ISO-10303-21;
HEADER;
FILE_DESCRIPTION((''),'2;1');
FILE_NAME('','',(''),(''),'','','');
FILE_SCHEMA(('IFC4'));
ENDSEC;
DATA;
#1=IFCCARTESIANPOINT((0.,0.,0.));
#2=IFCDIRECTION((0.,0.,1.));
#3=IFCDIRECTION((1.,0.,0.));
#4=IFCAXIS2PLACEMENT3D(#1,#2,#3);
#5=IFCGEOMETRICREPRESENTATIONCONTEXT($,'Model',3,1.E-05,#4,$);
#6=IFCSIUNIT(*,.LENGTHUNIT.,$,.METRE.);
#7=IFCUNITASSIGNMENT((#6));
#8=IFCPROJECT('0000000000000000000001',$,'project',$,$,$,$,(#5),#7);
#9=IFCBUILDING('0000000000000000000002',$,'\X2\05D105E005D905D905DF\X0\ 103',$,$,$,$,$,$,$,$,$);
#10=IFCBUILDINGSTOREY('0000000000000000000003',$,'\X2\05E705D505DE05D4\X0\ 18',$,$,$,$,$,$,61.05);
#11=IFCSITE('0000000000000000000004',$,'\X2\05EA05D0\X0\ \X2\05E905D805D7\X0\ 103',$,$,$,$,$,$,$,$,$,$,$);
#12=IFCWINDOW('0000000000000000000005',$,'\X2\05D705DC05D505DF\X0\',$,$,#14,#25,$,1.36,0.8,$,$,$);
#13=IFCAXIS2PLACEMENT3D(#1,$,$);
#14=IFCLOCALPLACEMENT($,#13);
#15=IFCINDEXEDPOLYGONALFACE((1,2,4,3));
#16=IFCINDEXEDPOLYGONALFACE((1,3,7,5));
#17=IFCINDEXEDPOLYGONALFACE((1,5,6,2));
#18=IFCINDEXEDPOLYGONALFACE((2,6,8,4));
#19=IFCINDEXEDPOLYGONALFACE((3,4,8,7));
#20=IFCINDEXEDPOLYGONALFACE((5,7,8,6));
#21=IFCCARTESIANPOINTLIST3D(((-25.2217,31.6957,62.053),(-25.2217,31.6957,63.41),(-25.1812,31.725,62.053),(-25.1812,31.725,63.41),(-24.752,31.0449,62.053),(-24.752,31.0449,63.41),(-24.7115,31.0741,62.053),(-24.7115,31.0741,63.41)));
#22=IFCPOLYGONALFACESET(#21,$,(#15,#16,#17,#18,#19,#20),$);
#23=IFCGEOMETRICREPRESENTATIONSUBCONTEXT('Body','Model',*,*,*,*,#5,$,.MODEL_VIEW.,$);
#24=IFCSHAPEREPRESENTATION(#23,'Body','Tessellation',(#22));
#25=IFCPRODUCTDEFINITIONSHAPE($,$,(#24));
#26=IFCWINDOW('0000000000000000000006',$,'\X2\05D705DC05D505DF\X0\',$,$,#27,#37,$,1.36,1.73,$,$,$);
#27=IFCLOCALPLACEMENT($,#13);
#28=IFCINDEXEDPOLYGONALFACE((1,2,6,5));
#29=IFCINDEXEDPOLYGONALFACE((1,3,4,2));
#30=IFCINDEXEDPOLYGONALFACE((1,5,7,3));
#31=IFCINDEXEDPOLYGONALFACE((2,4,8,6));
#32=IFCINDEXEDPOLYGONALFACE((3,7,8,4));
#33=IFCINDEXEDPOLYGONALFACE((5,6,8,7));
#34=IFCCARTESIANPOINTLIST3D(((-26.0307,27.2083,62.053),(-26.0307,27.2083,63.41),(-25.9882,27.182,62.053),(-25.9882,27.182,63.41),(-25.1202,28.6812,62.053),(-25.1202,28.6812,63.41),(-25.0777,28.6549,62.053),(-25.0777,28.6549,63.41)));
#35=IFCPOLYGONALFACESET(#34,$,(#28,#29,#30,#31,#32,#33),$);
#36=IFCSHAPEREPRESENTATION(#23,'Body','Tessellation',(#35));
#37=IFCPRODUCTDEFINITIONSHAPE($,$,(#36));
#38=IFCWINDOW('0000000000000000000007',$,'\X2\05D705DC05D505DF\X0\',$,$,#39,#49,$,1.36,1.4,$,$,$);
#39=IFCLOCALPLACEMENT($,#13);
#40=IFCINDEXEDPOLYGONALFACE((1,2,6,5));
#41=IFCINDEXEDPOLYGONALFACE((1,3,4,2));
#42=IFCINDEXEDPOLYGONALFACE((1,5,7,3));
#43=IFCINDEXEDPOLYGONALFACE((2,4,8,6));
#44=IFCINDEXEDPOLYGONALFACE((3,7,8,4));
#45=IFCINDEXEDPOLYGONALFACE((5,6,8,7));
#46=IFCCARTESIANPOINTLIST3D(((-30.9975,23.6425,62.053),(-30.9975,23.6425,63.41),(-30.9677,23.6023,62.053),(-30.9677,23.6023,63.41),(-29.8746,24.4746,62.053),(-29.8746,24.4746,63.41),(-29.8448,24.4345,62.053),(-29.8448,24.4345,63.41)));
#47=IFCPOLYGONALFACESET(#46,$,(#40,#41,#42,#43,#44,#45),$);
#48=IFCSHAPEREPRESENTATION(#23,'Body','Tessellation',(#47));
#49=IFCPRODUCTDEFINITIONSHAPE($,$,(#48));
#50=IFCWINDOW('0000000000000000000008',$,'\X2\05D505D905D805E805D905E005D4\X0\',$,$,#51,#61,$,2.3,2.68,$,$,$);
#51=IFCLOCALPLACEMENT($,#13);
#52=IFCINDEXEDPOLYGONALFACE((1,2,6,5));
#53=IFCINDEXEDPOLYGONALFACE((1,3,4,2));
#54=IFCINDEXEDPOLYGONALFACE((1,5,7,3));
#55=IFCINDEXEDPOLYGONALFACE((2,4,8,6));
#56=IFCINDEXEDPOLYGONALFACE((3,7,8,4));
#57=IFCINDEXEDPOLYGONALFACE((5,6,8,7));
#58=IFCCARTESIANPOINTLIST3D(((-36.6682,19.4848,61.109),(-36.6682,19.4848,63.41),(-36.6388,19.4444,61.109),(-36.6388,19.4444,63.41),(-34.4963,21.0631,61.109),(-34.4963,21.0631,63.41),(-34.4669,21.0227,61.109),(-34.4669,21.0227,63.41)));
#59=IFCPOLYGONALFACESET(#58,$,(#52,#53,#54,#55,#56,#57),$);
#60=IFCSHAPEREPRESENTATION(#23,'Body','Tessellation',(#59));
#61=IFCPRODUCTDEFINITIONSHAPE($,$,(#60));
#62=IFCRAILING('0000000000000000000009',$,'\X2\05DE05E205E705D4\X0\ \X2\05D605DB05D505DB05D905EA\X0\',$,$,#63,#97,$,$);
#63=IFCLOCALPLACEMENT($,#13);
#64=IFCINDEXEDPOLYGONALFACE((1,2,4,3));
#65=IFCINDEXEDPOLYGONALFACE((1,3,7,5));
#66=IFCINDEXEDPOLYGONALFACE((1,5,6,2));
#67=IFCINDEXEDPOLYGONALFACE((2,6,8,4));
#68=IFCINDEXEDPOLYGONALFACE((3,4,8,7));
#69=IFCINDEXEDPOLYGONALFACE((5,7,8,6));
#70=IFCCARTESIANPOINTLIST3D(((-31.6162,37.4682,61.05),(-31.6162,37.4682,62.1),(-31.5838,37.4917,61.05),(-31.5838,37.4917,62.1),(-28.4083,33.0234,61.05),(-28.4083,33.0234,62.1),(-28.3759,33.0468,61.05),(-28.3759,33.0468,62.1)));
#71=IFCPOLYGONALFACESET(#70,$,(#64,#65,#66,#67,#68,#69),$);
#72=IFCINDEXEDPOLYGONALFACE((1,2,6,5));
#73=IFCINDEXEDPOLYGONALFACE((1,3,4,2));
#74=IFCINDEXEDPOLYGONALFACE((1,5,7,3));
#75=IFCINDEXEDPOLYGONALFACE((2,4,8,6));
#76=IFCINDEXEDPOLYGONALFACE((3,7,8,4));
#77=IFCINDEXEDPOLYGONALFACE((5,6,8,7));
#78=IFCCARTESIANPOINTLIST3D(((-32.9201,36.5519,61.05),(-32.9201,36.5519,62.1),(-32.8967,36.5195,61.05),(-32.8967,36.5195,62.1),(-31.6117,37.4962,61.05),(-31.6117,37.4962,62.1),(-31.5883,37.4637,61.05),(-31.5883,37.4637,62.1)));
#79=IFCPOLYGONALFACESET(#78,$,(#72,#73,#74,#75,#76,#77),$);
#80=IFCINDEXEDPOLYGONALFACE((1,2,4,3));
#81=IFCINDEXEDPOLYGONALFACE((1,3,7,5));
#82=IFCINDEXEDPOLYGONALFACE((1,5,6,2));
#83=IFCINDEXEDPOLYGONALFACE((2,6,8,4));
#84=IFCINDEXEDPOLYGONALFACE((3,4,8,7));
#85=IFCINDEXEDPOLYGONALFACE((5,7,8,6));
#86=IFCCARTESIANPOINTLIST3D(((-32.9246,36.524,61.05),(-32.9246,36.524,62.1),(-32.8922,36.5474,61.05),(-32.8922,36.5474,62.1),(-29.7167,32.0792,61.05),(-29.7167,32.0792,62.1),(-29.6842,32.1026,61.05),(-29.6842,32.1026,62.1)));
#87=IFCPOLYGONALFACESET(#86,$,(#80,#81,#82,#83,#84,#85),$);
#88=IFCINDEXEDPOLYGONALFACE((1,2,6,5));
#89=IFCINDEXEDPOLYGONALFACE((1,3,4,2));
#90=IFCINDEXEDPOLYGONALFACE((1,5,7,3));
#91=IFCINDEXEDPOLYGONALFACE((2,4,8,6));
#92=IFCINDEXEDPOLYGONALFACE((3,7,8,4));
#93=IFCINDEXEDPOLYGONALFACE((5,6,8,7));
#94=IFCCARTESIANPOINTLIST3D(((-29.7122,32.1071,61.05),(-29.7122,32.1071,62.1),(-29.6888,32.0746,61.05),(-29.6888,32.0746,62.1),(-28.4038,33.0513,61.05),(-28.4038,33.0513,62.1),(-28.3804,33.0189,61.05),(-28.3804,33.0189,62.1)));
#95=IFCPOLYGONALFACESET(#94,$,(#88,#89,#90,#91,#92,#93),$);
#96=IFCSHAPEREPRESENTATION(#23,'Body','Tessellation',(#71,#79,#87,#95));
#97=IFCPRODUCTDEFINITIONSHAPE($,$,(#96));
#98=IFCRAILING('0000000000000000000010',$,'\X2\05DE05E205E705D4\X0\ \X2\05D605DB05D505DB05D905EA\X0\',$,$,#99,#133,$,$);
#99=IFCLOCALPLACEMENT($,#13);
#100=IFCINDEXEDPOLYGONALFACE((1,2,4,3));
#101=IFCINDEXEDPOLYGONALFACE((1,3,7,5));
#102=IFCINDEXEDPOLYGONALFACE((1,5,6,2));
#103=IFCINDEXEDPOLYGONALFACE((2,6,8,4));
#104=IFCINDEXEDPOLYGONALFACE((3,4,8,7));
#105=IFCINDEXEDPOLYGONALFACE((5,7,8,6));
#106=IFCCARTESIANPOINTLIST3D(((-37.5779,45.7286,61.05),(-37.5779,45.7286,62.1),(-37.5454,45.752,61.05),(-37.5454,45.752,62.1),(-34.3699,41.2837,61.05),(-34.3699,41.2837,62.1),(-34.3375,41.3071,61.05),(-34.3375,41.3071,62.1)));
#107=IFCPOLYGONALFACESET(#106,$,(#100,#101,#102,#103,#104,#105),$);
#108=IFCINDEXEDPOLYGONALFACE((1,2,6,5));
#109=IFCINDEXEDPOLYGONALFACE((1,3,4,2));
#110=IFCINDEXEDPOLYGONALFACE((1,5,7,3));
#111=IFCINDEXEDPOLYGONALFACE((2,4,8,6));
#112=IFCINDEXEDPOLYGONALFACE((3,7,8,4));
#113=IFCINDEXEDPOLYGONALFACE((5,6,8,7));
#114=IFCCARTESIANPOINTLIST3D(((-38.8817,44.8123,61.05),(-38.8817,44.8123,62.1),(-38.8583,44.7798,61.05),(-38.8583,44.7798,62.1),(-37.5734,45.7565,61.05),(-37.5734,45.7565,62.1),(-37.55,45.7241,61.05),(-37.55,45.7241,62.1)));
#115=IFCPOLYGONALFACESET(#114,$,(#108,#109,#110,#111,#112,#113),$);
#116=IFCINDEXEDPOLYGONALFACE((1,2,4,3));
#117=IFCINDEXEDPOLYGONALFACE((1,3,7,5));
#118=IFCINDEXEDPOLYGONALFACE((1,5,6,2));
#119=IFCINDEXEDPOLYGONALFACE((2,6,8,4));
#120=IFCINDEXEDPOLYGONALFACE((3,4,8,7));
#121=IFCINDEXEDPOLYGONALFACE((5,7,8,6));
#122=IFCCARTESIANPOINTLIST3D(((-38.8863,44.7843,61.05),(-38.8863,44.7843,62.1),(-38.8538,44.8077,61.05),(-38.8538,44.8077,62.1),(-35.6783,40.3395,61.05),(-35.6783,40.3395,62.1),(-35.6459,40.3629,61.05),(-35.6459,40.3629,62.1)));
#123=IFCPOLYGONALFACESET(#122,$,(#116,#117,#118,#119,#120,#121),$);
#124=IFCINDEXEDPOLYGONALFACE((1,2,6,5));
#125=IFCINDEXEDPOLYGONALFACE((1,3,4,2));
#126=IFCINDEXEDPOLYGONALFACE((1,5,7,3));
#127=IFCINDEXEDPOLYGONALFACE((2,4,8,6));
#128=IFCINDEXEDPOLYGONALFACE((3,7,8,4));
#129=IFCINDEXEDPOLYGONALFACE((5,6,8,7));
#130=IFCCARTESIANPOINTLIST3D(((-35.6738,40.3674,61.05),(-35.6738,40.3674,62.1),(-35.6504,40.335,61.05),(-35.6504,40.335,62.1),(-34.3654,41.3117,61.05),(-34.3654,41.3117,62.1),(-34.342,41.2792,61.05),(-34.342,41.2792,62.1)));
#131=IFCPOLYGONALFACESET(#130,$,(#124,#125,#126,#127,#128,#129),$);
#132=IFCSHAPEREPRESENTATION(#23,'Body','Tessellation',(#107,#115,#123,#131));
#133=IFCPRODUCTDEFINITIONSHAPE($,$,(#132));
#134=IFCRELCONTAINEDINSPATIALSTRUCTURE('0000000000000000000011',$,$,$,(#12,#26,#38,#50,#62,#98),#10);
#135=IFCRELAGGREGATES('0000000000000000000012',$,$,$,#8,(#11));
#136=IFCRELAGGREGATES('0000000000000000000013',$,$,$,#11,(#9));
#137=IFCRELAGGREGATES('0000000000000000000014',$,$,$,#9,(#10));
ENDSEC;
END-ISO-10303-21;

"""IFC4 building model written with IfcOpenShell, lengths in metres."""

from ifc_helpers import new_model, si_unit, frame, origin_with_axes, context, subcontext, project, spatial, polyline, outline, extrude, element, save


model = new_model("IFC4")

# Units and contexts
model_context = context("Model", 3, precision=1e-05, world=origin_with_axes())
body_context = subcontext(model_context, "Body", "Model", "MODEL_VIEW")
ifc_project = project(units=[si_unit("LENGTHUNIT", "METRE")], contexts=[model_context])

# Site, building, storey
site = spatial("IfcSite", under=ifc_project, Name="תא שטח 103")
building = spatial("IfcBuilding", under=site, Name="בניין 103")
storey = spatial("IfcBuildingStorey", under=building, Name="קומה 18", Elevation=61.05)

# Windows
element("IfcWindow", 1, inside=storey, Name="חלון", OverallHeight=1.36, OverallWidth=0.8, context=body_context, shape_type="SweptSolid", body=[
    extrude(outline(polyline([(-25.2217, 31.6957), (-24.752, 31.0449), (-24.7115, 31.0741), (-25.1812, 31.725), (-25.2217, 31.6957)])), frame((0.0, 0.0, 62.053)), (0.0, 0.0, 1.0), 1.357),
])
element("IfcWindow", 2, inside=storey, Name="חלון", OverallHeight=1.36, OverallWidth=1.73, context=body_context, shape_type="SweptSolid", body=[
    extrude(outline(polyline([(-25.1202, 28.6812), (-26.0307, 27.2083), (-25.9882, 27.182), (-25.0777, 28.6549), (-25.1202, 28.6812)])), frame((0.0, 0.0, 62.053)), (0.0, 0.0, 1.0), 1.357),
])
element("IfcWindow", 3, inside=storey, Name="חלון", OverallHeight=1.36, OverallWidth=1.4, context=body_context, shape_type="SweptSolid", body=[
    extrude(outline(polyline([(-29.8746, 24.4746), (-30.9975, 23.6425), (-30.9677, 23.6023), (-29.8448, 24.4345), (-29.8746, 24.4746)])), frame((0.0, 0.0, 62.053)), (0.0, 0.0, 1.0), 1.357),
])
element("IfcWindow", 4, inside=storey, Name="ויטרינה", OverallHeight=2.3, OverallWidth=2.68, context=body_context, shape_type="SweptSolid", body=[
    extrude(outline(polyline([(-34.4963, 21.0631), (-36.6682, 19.4848), (-36.6388, 19.4444), (-34.4669, 21.0227), (-34.4963, 21.0631)])), frame((0.0, 0.0, 61.109)), (0.0, 0.0, 1.0), 2.301),
])

# Railings
element("IfcRailing", 5, inside=storey, Name="מעקה זכוכית", context=body_context, shape_type="SweptSolid", body=[
    extrude(outline(polyline([(-28.3759, 33.0468), (-31.5838, 37.4917), (-31.6162, 37.4682), (-28.4083, 33.0234), (-28.3759, 33.0468)])), frame((0.0, 0.0, 61.05)), (0.0, 0.0, 1.0), 1.05),
    extrude(outline(polyline([(-31.6117, 37.4962), (-32.9201, 36.5519), (-32.8967, 36.5195), (-31.5883, 37.4637), (-31.6117, 37.4962)])), frame((0.0, 0.0, 61.05)), (0.0, 0.0, 1.0), 1.05),
    extrude(outline(polyline([(-32.9246, 36.524), (-29.7167, 32.0792), (-29.6842, 32.1026), (-32.8922, 36.5474), (-32.9246, 36.524)])), frame((0.0, 0.0, 61.05)), (0.0, 0.0, 1.0), 1.05),
    extrude(outline(polyline([(-29.6888, 32.0746), (-28.3804, 33.0189), (-28.4038, 33.0513), (-29.7122, 32.1071), (-29.6888, 32.0746)])), frame((0.0, 0.0, 61.05)), (0.0, 0.0, 1.0), 1.05),
])
element("IfcRailing", 6, inside=storey, Name="מעקה זכוכית", context=body_context, shape_type="SweptSolid", body=[
    extrude(outline(polyline([(-34.3375, 41.3071), (-37.5454, 45.752), (-37.5779, 45.7286), (-34.3699, 41.2837), (-34.3375, 41.3071)])), frame((0.0, 0.0, 61.05)), (0.0, 0.0, 1.0), 1.05),
    extrude(outline(polyline([(-37.5734, 45.7565), (-38.8817, 44.8123), (-38.8583, 44.7798), (-37.55, 45.7241), (-37.5734, 45.7565)])), frame((0.0, 0.0, 61.05)), (0.0, 0.0, 1.0), 1.05),
    extrude(outline(polyline([(-38.8863, 44.7843), (-35.6783, 40.3395), (-35.6459, 40.3629), (-38.8538, 44.8077), (-38.8863, 44.7843)])), frame((0.0, 0.0, 61.05)), (0.0, 0.0, 1.0), 1.05),
    extrude(outline(polyline([(-35.6504, 40.335), (-34.342, 41.2792), (-34.3654, 41.3117), (-35.6738, 40.3674), (-35.6504, 40.335)])), frame((0.0, 0.0, 61.05)), (0.0, 0.0, 1.0), 1.05),
])

save(model, "model.ifc")
